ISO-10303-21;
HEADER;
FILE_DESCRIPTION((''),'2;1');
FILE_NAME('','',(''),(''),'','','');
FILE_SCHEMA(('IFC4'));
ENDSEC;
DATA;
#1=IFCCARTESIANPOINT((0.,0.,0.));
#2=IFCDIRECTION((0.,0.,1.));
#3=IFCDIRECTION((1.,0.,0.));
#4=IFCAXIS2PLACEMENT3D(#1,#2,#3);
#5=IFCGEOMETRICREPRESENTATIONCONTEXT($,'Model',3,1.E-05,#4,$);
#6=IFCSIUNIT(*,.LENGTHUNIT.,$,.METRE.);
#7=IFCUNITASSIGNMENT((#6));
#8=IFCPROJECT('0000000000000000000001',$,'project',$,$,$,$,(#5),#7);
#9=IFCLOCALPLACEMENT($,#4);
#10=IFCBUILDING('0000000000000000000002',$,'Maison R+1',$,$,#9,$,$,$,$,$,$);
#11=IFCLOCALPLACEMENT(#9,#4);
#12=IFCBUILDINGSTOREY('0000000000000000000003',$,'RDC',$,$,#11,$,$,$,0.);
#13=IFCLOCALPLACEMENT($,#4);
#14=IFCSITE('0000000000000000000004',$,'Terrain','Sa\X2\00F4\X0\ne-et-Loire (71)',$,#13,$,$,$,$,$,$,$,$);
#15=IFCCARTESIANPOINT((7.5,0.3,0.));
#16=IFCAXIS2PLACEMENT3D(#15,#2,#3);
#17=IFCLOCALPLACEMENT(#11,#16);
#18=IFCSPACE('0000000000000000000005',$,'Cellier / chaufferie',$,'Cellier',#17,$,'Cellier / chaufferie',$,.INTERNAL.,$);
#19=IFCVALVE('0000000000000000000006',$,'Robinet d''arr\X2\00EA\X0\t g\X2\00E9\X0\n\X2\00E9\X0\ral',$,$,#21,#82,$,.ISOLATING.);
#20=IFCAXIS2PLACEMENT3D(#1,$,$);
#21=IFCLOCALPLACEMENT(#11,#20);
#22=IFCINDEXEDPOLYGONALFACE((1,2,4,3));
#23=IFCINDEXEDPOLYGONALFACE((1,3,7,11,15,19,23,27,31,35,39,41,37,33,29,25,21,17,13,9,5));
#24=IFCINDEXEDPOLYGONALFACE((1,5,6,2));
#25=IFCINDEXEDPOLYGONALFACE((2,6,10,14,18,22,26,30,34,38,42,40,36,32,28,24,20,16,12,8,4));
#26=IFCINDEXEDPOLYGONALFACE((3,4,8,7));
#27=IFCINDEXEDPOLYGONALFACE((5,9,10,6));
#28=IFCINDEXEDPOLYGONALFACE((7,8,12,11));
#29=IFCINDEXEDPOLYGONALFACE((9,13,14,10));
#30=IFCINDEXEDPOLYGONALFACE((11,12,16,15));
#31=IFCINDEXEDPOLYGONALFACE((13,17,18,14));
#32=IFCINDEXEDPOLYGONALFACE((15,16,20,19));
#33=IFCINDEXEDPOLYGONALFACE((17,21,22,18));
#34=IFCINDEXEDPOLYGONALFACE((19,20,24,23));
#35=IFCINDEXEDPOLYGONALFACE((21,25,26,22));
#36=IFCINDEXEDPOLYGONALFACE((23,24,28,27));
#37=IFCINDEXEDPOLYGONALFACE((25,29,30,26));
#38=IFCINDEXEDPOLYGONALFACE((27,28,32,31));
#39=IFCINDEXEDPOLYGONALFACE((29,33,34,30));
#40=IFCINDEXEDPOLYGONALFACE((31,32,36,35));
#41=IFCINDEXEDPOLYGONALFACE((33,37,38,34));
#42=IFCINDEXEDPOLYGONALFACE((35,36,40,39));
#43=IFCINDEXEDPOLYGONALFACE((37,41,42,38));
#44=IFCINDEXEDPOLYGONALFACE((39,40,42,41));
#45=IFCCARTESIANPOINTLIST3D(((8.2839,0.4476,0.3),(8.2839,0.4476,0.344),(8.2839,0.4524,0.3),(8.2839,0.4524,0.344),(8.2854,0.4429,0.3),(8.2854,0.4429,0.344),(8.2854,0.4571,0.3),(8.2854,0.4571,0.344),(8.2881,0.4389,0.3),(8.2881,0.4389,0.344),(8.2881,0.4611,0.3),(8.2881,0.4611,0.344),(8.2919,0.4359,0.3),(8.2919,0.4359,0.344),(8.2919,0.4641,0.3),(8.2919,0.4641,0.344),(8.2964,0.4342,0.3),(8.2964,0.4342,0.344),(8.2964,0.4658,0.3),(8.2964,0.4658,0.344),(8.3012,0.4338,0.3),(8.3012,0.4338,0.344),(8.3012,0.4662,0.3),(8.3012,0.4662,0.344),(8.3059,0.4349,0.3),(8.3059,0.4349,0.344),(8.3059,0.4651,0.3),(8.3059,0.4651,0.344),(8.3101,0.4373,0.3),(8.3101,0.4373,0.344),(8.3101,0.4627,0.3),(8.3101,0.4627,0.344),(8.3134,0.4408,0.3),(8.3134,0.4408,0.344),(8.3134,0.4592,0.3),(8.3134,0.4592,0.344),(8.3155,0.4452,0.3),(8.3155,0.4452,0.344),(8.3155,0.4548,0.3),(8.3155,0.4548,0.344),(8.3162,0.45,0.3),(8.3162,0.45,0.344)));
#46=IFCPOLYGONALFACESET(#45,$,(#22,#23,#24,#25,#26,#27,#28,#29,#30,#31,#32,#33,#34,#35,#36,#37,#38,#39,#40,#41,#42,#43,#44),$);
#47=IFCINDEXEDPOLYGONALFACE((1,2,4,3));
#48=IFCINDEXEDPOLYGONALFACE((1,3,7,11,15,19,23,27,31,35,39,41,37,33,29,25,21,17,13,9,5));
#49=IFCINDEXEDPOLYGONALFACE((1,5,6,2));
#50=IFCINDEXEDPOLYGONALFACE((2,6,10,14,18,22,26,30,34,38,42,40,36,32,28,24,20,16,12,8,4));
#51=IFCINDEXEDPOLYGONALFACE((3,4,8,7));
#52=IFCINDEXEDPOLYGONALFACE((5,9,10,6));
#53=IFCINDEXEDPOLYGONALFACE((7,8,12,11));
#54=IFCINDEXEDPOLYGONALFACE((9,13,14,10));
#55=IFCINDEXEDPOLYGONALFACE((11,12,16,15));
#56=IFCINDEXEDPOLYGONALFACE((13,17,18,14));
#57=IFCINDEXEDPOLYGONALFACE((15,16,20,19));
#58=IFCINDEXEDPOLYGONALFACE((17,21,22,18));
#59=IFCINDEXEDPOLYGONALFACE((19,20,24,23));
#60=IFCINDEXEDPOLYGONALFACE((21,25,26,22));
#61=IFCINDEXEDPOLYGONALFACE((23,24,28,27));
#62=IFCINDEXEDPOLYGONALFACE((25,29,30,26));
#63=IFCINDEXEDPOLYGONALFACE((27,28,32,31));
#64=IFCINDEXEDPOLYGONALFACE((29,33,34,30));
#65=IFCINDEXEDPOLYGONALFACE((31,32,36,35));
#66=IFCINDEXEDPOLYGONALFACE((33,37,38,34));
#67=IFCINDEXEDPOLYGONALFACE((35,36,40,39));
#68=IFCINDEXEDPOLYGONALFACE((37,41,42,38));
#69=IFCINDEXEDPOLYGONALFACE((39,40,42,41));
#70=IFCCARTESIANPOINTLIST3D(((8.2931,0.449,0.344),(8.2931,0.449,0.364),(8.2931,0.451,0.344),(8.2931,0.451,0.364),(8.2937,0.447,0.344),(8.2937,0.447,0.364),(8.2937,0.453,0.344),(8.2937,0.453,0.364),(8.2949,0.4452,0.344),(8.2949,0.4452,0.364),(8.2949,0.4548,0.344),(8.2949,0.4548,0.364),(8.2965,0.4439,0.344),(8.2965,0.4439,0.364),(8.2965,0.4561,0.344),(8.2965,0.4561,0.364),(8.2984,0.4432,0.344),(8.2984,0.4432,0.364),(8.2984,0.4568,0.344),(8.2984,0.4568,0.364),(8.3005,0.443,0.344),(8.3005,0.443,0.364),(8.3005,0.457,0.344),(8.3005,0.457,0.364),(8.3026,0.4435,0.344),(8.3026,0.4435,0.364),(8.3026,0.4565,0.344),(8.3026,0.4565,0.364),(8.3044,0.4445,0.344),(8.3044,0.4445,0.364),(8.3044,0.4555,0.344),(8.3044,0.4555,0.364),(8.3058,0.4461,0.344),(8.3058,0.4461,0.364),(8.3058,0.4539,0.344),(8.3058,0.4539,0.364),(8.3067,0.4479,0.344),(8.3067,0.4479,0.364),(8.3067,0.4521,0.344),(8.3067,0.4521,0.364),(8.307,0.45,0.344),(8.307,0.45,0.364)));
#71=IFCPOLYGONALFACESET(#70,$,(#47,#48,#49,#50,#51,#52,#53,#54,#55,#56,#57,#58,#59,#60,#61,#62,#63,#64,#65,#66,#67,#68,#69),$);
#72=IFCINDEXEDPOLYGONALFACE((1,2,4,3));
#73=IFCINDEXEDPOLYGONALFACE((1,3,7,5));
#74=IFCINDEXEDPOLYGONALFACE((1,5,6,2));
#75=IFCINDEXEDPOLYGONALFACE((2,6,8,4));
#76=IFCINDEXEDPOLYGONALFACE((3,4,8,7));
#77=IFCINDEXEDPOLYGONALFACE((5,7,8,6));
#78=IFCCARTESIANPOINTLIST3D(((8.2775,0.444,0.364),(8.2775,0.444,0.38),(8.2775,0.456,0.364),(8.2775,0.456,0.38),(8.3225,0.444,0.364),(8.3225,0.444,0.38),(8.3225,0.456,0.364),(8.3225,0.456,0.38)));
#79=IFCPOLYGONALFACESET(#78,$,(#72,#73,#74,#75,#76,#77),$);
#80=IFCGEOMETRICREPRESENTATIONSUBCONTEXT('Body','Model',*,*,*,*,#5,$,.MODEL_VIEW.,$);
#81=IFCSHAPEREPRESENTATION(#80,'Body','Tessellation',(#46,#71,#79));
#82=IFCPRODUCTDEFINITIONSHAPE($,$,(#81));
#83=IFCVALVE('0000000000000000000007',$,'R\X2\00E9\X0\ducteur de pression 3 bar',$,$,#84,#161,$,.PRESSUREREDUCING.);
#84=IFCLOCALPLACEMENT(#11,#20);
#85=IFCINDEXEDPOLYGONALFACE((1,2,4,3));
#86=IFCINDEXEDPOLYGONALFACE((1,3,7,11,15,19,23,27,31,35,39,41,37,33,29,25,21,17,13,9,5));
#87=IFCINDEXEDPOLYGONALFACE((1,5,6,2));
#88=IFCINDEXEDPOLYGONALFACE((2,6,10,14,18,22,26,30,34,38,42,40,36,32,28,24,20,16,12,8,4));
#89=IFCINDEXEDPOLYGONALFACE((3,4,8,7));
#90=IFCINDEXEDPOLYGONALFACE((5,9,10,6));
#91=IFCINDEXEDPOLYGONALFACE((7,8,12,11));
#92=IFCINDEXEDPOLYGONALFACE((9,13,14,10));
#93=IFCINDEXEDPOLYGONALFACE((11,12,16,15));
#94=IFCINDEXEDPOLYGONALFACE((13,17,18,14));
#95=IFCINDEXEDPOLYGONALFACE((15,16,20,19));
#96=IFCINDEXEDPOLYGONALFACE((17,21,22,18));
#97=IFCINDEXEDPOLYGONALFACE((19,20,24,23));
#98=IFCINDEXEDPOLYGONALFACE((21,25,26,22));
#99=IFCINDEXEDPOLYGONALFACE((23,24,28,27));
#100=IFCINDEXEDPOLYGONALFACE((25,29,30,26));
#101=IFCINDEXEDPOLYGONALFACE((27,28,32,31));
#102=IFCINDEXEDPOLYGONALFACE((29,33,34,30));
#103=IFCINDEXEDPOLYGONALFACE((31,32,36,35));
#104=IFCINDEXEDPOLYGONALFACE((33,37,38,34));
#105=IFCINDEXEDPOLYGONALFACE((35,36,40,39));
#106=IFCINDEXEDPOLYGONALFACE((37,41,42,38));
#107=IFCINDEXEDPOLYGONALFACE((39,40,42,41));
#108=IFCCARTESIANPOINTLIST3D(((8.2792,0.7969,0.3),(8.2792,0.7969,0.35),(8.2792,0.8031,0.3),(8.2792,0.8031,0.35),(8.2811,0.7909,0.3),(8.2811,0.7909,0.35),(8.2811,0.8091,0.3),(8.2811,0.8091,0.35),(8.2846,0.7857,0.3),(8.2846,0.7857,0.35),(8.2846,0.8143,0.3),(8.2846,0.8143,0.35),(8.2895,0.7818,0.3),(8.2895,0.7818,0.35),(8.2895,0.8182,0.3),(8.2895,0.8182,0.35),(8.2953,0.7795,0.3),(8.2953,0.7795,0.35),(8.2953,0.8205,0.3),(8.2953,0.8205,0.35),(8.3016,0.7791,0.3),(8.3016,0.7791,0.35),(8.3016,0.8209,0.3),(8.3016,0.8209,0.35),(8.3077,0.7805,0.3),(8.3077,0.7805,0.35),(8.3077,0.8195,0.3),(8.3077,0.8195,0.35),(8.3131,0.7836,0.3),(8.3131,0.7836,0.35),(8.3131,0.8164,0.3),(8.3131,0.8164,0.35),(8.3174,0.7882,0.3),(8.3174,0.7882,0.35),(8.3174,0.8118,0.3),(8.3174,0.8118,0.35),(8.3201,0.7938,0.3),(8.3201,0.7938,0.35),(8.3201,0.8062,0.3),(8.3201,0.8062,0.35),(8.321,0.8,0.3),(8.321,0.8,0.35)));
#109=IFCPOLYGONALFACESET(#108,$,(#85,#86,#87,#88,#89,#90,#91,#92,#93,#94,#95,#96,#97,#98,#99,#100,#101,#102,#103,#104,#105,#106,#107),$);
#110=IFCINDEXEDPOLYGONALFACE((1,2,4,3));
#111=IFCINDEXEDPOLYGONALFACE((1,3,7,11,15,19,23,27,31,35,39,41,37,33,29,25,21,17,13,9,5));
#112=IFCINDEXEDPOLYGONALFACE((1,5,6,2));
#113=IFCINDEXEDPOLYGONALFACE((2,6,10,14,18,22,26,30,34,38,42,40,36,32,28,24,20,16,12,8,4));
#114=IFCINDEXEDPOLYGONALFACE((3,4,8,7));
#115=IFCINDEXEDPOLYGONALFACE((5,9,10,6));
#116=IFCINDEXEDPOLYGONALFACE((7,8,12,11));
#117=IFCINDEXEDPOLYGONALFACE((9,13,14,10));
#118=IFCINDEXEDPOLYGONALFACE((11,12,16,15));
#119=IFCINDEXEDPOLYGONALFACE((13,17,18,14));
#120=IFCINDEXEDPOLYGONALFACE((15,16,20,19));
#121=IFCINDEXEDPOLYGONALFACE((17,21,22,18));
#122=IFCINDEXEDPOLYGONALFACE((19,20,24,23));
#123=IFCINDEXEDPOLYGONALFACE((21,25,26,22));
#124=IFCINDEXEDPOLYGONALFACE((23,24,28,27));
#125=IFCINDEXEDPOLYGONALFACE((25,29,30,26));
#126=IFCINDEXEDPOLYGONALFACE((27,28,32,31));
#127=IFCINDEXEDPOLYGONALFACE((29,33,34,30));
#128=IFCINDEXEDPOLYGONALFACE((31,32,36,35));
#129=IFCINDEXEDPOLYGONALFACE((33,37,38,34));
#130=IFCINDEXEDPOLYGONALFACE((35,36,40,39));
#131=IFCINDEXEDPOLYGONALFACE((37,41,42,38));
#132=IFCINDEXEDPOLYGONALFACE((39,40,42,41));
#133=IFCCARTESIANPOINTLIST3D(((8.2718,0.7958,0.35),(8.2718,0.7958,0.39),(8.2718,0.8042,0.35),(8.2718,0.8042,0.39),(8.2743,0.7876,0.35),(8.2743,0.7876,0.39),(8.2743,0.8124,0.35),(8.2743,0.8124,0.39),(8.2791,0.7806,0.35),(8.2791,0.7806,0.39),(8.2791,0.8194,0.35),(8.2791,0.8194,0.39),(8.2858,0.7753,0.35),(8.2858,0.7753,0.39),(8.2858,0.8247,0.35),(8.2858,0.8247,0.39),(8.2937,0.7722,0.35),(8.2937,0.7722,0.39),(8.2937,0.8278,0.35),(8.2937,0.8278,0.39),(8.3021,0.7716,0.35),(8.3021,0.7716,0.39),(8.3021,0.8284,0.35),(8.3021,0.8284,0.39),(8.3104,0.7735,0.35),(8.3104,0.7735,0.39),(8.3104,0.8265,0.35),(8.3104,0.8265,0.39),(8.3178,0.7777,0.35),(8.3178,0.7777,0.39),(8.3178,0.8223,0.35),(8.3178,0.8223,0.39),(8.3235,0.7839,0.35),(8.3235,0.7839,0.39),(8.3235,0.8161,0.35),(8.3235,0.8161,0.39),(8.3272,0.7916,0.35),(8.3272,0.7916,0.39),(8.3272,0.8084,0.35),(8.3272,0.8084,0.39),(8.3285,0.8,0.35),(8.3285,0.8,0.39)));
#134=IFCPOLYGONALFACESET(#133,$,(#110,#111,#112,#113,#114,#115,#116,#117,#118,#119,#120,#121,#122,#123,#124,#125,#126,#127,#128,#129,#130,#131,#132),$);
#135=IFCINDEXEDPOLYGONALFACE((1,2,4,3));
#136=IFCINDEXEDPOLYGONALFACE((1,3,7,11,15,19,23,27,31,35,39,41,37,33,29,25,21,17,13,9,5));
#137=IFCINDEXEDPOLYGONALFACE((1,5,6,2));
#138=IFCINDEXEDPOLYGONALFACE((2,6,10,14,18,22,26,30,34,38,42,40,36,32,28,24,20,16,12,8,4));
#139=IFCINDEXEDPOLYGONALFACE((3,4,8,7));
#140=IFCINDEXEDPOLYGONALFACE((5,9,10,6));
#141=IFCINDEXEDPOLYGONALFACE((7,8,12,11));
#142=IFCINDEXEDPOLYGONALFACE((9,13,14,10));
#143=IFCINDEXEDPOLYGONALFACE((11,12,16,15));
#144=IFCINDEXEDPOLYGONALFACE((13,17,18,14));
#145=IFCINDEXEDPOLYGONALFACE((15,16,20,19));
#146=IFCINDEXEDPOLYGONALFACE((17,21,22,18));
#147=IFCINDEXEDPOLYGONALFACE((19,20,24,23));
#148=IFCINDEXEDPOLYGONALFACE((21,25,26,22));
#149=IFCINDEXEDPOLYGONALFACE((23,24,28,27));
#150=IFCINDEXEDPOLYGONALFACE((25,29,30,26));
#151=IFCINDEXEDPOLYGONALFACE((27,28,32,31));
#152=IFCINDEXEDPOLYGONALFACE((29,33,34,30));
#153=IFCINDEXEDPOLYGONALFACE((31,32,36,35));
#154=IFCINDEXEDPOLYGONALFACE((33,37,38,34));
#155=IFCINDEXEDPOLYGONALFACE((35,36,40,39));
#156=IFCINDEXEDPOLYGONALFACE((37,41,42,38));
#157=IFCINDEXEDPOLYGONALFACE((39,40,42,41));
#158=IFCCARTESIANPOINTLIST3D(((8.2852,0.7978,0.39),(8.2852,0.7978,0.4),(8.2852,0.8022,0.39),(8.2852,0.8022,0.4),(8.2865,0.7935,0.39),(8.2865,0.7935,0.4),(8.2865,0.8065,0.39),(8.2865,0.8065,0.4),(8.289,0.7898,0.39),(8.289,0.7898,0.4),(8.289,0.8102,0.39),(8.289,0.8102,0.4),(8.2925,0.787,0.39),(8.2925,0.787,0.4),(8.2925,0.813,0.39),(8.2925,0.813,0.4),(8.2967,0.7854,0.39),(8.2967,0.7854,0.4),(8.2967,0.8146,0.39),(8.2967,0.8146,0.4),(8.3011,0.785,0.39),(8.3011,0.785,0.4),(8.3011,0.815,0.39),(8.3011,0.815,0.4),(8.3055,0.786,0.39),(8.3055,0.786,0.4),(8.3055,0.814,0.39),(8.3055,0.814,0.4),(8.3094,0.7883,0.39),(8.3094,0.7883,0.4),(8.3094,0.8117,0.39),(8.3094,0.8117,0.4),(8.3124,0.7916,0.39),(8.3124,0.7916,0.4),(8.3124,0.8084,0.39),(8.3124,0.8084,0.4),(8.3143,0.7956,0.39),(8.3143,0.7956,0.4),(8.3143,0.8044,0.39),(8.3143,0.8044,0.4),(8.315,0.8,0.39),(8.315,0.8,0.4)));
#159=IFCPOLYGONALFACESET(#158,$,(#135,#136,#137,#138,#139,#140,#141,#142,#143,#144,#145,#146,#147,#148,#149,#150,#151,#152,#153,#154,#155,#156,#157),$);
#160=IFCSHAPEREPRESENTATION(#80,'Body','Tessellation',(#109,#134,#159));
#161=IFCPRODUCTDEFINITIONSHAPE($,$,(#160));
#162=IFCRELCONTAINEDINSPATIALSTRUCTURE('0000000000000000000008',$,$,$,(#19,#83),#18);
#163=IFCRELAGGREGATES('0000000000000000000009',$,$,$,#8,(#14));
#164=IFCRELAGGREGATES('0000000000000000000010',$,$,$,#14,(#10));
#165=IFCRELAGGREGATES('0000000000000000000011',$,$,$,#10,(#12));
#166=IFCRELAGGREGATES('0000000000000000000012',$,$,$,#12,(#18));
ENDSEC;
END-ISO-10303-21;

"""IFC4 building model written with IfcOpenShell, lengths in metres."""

from ifc_helpers import new_model, si_unit, frame, frame_2d, origin_with_axes, place, context, subcontext, project, spatial, rectangle, circle, extrude, element, save


model = new_model("IFC4")

# Units and contexts
model_context = context("Model", 3, precision=1e-05, world=origin_with_axes())
body_context = subcontext(model_context, "Body", "Model", "MODEL_VIEW")
ifc_project = project(units=[si_unit("LENGTHUNIT", "METRE")], contexts=[model_context])

# Site, building, storey
site_placement = place(None, origin_with_axes())
site = spatial("IfcSite", under=ifc_project, at=site_placement, Name="Terrain", Description="Saône-et-Loire (71)")
building_placement = place(None, origin_with_axes())
building = spatial("IfcBuilding", under=site, at=building_placement, Name="Maison R+1")
storey_placement = place(building_placement, origin_with_axes())
storey = spatial("IfcBuildingStorey", under=building, at=storey_placement, Name="RDC", Elevation=0.0)

# Shared definitions
space_placement = place(storey_placement, frame((7.5, 0.3, 0.0), z_axis=(0.0, 0.0, 1.0), x_axis=(1.0, 0.0, 0.0)))
space = spatial("IfcSpace", under=storey, at=space_placement, Name="Cellier / chaufferie", ObjectType="Cellier", LongName="Cellier / chaufferie", PredefinedType="INTERNAL")

# Valves
valve_1_placement = place(space_placement, frame((0.8, 0.15, 0.3), z_axis=(0.0, 0.0, 1.0), x_axis=(1.0, 0.0, 0.0)))
element("IfcValve", 1, at=valve_1_placement, inside=space, Name="Robinet d'arrêt général", PredefinedType="ISOLATING", context=body_context, shape_type="SweptSolid", body=[
    extrude(circle(Radius=0.0163), origin_with_axes(), (0.0, 0.0, 1.0), 0.044),
    extrude(circle(Radius=0.007), frame((0.0, 0.0, 0.044), z_axis=(0.0, 0.0, 1.0), x_axis=(1.0, 0.0, 0.0)), (0.0, 0.0, 1.0), 0.02),
    extrude(rectangle(XDim=0.045, YDim=0.012, at=frame_2d((0.0225, 0.006))), frame((-0.0225, -0.006, 0.064), z_axis=(0.0, 0.0, 1.0), x_axis=(1.0, 0.0, 0.0)), (0.0, 0.0, 1.0), 0.016),
])
valve_2_placement = place(space_placement, frame((0.8, 0.5, 0.3), z_axis=(0.0, 0.0, 1.0), x_axis=(1.0, 0.0, 0.0)))
element("IfcValve", 2, at=valve_2_placement, inside=space, Name="Réducteur de pression 3 bar", PredefinedType="PRESSUREREDUCING", context=body_context, shape_type="SweptSolid", body=[
    extrude(circle(Radius=0.021), origin_with_axes(), (0.0, 0.0, 1.0), 0.05),
    extrude(circle(Radius=0.0285), frame((0.0, 0.0, 0.05), z_axis=(0.0, 0.0, 1.0), x_axis=(1.0, 0.0, 0.0)), (0.0, 0.0, 1.0), 0.04),
    extrude(circle(Radius=0.015), frame((0.0, 0.0, 0.09), z_axis=(0.0, 0.0, 1.0), x_axis=(1.0, 0.0, 0.0)), (0.0, 0.0, 1.0), 0.01),
])

save(model, "model.ifc")
